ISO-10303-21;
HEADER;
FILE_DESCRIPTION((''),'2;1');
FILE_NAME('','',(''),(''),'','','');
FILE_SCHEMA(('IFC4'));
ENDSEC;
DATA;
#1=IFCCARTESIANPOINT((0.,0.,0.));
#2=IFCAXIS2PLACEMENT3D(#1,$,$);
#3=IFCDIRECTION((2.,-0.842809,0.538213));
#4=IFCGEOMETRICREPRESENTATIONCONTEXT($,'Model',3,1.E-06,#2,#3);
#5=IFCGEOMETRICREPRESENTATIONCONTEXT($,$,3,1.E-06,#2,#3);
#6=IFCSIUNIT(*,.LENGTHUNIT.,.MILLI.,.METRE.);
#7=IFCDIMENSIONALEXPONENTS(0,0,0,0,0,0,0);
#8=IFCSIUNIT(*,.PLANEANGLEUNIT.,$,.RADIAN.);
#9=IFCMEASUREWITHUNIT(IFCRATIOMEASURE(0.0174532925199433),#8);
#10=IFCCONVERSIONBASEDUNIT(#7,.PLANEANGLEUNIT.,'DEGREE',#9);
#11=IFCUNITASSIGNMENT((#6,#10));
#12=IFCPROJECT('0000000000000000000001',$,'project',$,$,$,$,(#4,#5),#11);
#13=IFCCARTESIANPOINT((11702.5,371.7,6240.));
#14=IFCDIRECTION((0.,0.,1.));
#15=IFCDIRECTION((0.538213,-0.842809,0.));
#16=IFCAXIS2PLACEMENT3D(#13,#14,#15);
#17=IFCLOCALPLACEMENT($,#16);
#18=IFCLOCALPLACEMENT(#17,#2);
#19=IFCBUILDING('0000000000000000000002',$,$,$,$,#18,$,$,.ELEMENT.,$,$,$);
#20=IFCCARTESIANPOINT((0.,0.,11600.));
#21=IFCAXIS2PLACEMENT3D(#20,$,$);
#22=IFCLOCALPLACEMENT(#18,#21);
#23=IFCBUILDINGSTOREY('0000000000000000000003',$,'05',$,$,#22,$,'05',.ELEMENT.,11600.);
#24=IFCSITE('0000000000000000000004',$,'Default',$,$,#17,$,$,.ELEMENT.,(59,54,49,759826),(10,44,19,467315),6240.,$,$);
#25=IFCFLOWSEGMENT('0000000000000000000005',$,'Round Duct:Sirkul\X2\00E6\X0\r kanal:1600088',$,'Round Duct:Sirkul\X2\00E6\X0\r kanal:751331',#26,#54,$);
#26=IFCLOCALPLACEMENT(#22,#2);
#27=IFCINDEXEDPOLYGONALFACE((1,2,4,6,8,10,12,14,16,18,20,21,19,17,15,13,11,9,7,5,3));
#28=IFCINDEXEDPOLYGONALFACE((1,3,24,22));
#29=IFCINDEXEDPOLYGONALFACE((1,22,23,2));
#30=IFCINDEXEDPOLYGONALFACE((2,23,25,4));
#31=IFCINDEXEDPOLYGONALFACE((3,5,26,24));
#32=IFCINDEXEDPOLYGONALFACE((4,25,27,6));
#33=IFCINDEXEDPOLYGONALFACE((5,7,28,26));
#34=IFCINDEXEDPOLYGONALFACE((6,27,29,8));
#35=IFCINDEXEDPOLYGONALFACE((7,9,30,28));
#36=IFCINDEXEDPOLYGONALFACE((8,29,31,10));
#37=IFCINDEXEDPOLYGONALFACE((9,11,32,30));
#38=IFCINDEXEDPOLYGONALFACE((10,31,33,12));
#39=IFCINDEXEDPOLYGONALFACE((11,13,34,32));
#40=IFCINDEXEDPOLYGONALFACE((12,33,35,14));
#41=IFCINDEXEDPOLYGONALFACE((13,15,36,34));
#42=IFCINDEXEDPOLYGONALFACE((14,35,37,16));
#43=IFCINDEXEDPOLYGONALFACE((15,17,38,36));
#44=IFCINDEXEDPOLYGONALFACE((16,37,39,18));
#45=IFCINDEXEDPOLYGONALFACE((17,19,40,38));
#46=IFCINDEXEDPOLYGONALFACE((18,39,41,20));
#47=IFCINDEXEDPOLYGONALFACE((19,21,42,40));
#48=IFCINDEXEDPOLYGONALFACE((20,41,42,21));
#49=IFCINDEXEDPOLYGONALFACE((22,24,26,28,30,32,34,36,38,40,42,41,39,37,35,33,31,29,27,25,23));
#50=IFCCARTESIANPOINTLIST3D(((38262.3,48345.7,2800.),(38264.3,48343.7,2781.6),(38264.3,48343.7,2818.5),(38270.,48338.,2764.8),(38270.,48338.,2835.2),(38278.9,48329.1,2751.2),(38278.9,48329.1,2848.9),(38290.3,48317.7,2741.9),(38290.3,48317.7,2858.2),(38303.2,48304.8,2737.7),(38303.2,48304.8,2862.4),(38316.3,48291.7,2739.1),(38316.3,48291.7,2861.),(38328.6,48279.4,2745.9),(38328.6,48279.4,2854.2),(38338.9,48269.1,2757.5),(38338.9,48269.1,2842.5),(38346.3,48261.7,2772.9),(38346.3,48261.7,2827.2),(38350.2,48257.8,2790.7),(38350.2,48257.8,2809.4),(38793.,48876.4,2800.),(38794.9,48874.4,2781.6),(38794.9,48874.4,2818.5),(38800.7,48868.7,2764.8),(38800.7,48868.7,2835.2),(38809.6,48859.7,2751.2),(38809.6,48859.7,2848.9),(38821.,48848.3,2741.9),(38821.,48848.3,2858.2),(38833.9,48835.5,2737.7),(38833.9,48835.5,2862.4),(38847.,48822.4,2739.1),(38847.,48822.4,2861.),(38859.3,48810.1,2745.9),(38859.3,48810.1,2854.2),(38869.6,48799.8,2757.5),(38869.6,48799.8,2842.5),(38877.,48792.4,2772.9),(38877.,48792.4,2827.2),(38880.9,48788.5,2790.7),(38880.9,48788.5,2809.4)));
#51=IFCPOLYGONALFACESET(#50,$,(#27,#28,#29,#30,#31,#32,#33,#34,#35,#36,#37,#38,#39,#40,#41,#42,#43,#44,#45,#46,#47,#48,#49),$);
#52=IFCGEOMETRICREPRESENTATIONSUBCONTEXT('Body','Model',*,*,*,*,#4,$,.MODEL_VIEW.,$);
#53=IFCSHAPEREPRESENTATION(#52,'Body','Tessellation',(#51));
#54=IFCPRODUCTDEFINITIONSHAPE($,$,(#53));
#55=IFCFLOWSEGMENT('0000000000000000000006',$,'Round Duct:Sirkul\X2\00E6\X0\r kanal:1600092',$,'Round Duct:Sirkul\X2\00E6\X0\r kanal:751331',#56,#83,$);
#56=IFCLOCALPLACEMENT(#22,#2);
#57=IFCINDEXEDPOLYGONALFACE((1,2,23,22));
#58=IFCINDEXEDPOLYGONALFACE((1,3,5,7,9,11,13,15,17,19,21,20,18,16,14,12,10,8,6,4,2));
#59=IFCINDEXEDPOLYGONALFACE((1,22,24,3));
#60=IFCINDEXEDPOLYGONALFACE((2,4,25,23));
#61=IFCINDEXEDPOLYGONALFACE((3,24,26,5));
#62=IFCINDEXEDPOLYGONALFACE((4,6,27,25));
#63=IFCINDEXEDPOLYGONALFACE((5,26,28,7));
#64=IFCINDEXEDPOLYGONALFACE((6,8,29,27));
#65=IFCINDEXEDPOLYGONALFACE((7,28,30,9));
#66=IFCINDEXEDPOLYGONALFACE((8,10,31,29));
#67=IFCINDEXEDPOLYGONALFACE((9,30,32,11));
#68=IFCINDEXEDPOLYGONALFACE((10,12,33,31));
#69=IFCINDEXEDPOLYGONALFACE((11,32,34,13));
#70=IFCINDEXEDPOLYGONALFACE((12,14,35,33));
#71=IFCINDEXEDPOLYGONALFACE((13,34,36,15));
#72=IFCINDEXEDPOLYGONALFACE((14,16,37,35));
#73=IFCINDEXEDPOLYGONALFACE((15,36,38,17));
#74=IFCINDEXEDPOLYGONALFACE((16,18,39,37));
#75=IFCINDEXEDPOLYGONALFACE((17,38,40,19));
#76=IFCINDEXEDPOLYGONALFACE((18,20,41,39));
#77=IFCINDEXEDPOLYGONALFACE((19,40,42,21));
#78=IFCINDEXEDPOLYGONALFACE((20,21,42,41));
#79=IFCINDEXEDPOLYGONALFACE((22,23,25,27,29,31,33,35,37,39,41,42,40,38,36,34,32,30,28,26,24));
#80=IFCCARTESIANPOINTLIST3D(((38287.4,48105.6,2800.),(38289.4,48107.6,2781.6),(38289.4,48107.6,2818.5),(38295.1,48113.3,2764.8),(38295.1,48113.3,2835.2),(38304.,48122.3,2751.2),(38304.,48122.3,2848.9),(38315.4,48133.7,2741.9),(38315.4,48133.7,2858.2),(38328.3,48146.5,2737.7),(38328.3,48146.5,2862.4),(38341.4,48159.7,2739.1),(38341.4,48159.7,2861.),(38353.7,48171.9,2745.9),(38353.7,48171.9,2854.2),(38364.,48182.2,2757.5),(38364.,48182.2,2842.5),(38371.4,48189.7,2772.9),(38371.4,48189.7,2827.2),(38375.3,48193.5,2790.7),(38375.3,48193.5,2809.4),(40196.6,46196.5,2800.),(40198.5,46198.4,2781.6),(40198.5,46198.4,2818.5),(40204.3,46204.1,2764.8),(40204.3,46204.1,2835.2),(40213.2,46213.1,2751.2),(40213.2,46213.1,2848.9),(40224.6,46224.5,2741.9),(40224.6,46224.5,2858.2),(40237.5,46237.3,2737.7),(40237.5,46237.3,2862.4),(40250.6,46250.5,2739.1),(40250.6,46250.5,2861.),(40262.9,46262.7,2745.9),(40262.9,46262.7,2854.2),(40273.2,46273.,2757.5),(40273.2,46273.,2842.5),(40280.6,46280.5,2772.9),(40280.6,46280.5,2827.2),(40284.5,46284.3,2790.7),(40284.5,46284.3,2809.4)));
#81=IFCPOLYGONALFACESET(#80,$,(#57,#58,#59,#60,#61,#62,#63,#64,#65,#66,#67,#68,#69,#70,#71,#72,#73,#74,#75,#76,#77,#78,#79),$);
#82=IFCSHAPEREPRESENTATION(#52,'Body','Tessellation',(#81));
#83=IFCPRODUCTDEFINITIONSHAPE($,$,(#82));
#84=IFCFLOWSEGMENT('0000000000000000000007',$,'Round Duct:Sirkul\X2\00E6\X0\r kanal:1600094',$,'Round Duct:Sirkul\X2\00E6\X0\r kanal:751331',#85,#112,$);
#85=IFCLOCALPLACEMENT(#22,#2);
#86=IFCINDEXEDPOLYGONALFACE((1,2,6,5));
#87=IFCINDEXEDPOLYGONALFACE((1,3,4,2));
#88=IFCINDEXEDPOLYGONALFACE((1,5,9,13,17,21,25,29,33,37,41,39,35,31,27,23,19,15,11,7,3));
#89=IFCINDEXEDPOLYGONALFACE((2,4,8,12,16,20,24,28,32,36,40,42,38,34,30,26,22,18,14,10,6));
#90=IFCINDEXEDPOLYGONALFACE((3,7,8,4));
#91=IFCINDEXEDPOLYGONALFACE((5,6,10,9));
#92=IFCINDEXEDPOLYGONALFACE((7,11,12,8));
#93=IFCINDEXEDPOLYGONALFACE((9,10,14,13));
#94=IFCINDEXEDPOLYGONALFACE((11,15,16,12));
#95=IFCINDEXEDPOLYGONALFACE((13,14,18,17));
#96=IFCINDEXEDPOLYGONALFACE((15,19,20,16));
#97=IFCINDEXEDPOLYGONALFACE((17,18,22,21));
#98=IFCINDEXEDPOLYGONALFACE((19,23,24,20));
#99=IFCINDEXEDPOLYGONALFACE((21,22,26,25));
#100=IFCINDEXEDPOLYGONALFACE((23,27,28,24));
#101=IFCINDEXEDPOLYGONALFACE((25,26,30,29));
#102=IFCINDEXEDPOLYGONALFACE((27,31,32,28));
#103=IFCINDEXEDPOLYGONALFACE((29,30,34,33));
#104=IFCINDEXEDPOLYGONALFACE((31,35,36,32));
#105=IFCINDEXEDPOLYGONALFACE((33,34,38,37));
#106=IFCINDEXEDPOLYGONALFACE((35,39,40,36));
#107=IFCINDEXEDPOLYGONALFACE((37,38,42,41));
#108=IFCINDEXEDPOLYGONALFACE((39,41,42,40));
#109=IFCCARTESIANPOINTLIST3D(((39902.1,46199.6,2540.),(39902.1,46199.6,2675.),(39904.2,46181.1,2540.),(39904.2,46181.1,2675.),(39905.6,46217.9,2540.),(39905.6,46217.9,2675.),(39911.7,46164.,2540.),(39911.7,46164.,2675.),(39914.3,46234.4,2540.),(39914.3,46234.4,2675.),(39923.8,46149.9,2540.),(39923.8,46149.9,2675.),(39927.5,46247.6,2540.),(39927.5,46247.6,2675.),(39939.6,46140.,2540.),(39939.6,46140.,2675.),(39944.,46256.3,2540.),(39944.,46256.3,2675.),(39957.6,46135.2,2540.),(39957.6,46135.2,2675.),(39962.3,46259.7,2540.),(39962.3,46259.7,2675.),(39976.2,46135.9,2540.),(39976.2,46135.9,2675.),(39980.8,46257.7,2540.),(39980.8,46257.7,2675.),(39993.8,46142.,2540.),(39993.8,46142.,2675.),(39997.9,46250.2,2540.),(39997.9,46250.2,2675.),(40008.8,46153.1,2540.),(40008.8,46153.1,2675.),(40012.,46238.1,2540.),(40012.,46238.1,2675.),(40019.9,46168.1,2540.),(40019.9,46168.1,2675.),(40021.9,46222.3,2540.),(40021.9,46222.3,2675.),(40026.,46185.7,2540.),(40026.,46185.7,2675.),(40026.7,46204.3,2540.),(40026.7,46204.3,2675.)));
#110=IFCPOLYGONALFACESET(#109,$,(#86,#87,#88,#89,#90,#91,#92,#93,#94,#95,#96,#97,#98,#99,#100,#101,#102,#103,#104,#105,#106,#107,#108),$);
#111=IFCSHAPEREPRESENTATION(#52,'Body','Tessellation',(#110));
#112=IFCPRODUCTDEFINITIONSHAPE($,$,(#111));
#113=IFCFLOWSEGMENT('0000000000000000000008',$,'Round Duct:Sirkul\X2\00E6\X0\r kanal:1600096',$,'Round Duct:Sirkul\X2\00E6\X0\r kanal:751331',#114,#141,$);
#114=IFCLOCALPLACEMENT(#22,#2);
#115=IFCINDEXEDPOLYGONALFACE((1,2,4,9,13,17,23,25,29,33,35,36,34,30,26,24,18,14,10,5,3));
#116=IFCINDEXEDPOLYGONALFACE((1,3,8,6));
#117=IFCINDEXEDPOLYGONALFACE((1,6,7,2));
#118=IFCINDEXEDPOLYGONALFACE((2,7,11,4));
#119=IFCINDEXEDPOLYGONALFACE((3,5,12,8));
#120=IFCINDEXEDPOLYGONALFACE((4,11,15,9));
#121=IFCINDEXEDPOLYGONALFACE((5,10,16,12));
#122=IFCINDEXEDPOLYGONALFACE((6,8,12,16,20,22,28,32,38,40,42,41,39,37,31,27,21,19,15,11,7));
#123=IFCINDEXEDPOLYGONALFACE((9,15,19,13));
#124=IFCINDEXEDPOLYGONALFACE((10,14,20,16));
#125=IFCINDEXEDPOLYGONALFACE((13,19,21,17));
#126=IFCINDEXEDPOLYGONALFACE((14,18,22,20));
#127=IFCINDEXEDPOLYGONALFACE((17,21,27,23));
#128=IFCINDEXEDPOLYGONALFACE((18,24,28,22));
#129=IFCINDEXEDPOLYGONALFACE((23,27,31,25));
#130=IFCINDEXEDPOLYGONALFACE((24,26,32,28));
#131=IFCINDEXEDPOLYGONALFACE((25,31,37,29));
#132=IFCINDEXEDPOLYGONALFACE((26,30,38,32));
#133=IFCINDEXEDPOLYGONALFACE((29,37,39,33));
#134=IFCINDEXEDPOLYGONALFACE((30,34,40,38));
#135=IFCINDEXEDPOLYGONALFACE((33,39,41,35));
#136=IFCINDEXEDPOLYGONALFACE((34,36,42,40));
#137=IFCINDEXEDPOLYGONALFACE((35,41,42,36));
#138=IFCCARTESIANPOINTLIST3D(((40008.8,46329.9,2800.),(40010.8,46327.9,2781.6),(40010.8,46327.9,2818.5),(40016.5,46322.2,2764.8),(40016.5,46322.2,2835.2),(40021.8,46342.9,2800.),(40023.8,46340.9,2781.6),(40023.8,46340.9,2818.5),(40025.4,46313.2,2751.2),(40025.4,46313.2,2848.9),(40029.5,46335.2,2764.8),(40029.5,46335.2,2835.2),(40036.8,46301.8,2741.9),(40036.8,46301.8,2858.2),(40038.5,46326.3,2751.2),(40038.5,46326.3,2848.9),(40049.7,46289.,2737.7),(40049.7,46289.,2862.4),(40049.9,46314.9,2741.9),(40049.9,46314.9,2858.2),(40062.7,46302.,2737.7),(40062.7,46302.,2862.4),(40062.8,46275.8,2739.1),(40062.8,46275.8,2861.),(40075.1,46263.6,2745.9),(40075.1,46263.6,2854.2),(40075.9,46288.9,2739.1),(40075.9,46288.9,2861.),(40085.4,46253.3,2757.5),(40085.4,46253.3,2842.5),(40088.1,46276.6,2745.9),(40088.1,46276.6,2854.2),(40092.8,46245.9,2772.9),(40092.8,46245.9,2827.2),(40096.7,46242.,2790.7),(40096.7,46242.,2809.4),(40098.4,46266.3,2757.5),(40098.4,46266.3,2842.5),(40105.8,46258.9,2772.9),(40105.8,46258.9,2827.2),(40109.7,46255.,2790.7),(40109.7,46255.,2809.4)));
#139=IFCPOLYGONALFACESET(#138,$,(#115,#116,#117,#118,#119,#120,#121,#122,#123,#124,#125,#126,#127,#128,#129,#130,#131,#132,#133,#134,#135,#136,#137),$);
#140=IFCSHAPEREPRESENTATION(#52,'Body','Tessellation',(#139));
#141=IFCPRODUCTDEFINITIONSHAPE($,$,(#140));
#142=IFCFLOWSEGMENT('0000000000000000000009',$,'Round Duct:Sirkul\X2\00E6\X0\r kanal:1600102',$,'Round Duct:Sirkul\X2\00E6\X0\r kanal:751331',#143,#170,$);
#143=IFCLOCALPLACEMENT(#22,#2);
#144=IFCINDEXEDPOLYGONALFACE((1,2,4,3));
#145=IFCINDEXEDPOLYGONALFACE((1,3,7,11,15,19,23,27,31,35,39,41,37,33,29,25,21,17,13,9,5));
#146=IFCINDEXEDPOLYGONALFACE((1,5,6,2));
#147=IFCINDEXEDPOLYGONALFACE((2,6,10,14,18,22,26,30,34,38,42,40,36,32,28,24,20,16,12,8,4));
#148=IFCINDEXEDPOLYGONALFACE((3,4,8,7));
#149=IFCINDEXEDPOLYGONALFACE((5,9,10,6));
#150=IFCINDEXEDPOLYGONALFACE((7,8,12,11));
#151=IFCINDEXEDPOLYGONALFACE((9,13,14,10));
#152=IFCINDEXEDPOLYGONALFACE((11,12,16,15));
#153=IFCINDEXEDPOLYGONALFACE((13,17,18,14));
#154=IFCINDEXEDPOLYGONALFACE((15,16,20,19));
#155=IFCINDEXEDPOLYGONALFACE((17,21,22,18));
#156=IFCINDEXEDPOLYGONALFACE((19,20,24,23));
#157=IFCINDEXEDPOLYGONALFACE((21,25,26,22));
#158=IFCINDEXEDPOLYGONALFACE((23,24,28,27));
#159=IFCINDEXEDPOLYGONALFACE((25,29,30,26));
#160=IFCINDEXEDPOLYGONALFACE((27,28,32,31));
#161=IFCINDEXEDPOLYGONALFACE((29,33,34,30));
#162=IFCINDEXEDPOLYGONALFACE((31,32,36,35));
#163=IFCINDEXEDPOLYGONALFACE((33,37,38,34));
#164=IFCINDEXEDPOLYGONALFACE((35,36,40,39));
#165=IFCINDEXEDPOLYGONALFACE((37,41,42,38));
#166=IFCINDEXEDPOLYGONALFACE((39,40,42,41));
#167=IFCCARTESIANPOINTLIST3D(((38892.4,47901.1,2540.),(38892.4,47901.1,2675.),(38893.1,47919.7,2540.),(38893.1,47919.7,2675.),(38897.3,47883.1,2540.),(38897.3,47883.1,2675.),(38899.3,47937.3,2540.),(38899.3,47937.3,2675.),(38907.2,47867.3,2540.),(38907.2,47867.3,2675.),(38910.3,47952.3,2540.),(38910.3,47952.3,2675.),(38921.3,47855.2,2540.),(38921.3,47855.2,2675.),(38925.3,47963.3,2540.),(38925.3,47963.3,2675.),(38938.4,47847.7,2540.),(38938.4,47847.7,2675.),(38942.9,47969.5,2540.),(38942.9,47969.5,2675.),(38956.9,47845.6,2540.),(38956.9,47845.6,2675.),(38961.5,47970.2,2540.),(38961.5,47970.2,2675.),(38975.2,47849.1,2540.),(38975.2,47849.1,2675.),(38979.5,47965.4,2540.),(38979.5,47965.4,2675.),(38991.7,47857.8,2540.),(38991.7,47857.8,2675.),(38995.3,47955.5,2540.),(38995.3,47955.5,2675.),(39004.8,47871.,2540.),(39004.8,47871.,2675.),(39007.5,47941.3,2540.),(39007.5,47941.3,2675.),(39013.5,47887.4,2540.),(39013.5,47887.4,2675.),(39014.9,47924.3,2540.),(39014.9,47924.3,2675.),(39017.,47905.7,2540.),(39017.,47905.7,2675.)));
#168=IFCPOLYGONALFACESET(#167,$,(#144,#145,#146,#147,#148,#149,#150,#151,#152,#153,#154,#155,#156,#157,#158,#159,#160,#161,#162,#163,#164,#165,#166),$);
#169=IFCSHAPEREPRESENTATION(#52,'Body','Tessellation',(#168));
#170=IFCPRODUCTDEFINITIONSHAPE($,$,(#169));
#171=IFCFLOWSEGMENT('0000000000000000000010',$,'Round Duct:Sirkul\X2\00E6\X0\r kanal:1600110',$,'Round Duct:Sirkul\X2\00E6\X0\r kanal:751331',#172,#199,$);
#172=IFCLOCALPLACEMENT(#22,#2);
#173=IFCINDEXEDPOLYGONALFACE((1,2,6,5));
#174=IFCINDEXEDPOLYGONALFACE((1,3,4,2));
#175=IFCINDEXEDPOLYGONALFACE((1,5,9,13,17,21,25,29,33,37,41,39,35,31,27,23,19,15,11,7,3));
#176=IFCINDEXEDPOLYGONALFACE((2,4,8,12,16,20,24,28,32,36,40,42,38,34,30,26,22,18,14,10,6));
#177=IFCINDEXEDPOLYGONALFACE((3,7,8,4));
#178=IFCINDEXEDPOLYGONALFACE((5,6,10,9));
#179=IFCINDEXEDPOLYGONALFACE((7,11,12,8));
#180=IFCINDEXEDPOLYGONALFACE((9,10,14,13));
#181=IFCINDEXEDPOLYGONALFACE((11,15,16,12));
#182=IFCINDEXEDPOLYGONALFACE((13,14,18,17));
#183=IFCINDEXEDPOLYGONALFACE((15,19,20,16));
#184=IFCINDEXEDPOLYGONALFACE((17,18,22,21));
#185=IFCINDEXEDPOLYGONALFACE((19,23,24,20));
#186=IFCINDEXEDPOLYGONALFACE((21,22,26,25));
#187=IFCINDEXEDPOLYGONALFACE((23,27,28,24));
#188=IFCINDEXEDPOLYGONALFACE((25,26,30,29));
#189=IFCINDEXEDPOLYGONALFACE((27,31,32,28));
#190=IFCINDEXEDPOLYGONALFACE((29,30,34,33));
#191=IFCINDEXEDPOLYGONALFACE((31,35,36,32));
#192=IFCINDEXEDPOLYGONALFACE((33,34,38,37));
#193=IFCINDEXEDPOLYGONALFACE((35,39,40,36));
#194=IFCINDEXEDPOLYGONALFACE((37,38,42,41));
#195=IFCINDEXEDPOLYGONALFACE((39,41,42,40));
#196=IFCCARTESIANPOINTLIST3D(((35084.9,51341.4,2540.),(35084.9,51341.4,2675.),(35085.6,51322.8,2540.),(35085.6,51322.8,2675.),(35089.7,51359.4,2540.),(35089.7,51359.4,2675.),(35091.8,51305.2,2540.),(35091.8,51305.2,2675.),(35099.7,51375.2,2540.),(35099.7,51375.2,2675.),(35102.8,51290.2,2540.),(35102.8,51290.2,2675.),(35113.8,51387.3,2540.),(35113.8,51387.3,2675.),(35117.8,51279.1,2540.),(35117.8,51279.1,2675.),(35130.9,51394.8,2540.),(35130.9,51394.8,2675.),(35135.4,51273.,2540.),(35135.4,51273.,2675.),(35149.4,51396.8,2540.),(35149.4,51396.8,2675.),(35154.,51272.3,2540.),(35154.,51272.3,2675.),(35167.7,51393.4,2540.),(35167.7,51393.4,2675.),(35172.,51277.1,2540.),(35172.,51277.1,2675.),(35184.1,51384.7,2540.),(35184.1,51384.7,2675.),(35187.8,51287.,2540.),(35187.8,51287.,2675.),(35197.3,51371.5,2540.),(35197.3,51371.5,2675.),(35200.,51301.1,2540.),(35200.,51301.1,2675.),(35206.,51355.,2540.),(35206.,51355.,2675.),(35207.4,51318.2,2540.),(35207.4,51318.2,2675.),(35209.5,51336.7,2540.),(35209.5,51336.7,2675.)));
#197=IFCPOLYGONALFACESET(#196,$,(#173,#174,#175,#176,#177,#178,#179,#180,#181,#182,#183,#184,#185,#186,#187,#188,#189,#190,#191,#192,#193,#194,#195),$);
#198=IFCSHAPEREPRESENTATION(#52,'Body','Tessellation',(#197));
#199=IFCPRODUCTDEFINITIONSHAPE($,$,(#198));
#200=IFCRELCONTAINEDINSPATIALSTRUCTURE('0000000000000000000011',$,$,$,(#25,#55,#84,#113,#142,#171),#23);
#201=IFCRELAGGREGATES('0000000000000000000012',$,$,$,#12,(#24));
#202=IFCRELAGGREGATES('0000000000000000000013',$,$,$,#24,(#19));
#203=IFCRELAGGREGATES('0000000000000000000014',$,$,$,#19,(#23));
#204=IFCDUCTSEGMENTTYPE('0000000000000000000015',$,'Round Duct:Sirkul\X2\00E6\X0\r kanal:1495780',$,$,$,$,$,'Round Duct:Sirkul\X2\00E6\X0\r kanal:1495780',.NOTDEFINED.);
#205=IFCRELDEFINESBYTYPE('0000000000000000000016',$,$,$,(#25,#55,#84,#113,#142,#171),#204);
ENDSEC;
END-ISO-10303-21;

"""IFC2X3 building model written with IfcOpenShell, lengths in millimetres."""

from ifc_helpers import new_model, entity, si_unit, converted_unit, direction, frame, frame_2d, origin, origin_2d_with_axis, place, context, subcontext, project, spatial, circle, extrude, type_object, element, save


model = new_model("IFC2X3")

# Units and contexts
model_context = context("Model", 3, precision=1e-06, world=origin(), true_north=direction((2.0, -0.842809, 0.538213)))
context_of_model = context(None, 3, precision=1e-06, world=origin(), true_north=direction((2.0, -0.842809, 0.538213)))
body_context = subcontext(model_context, "Body", "Model", "MODEL_VIEW")
ifc_project = project(units=[si_unit("LENGTHUNIT", "METRE", prefix="MILLI"), converted_unit("PLANEANGLEUNIT", "DEGREE", entity("IfcRatioMeasure", 0.0174532925199433), si_unit("PLANEANGLEUNIT", "RADIAN"), dimensions=[0, 0, 0, 0, 0, 0, 0])], contexts=[model_context, context_of_model])

# Site, building, storey
site_placement = place(None, frame((11702.5, 371.7, 6240.0), z_axis=(0.0, 0.0, 1.0), x_axis=(0.538213, -0.842809, 0.0)))
site = spatial("IfcSite", under=ifc_project, at=site_placement, Name="Default", CompositionType="ELEMENT", RefLatitude=(59, 54, 49, 759826), RefLongitude=(10, 44, 19, 467315), RefElevation=6240.0)
building_placement = place(site_placement, origin())
building = spatial("IfcBuilding", under=site, at=building_placement, CompositionType="ELEMENT")
storey_placement = place(building_placement, frame((0.0, 0.0, 11600.0)))
storey = spatial("IfcBuildingStorey", under=building, at=storey_placement, Name="05", LongName="05", CompositionType="ELEMENT", Elevation=11600.0)

# Flow segments
duct_segment_type = type_object("IfcDuctSegmentType", Name="Round Duct:Sirkulær kanal:1495780", ElementType="Round Duct:Sirkulær kanal:1495780", PredefinedType="NOTDEFINED")
flow_segment_1_placement = place(storey_placement, origin())
element("IfcFlowSegment", 1, at=flow_segment_1_placement, inside=storey, type_object=duct_segment_type, Name="Round Duct:Sirkulær kanal:1600088", ObjectType="Round Duct:Sirkulær kanal:751331", context=body_context, shape_type="SweptSolid", body=[
    extrude(circle(Radius=62.5, at=origin_2d_with_axis()), frame((38306.5, 48301.5, 2800.0), z_axis=(0.707107, 0.707107, 0.0), x_axis=(-0.707107, 0.707107, 0.0)), (0.0, 0.0, 1.0), 750.5),
])
flow_segment_2_placement = place(storey_placement, origin())
element("IfcFlowSegment", 2, at=flow_segment_2_placement, inside=storey, type_object=duct_segment_type, Name="Round Duct:Sirkulær kanal:1600092", ObjectType="Round Duct:Sirkulær kanal:751331", context=body_context, shape_type="SweptSolid", body=[
    extrude(circle(Radius=62.5, at=origin_2d_with_axis()), frame((38331.6, 48149.8, 2800.0), z_axis=(0.707107, -0.707107, 0.0), x_axis=(-0.707107, -0.707107, 0.0)), (0.0, 0.0, 1.0), 2700.0),
])
flow_segment_3_placement = place(storey_placement, origin())
element("IfcFlowSegment", 3, at=flow_segment_3_placement, inside=storey, type_object=duct_segment_type, Name="Round Duct:Sirkulær kanal:1600094", ObjectType="Round Duct:Sirkulær kanal:751331", context=body_context, shape_type="SweptSolid", body=[
    extrude(circle(Radius=62.5, at=origin_2d_with_axis()), frame((39964.6, 46197.3, 2540.0), z_axis=(0.0, 0.0, 1.0), x_axis=(0.707107, -0.707107, 0.0)), (0.0, 0.0, 1.0), 135.0),
])
flow_segment_4_placement = place(storey_placement, origin())
element("IfcFlowSegment", 4, at=flow_segment_4_placement, inside=storey, type_object=duct_segment_type, Name="Round Duct:Sirkulær kanal:1600096", ObjectType="Round Duct:Sirkulær kanal:751331", context=body_context, shape_type="SweptSolid", body=[
    extrude(circle(Radius=62.5, at=frame_2d((0.0, 0.0), x_axis=(1.0, 0.0))), frame((40053.0, 46285.7, 2800.0), z_axis=(0.707107, 0.707107, 0.0), x_axis=(-0.707107, 0.707107, 0.0)), (0.0, 0.0, 1.0), 18.4),
])
flow_segment_5_placement = place(storey_placement, origin())
element("IfcFlowSegment", 5, at=flow_segment_5_placement, inside=storey, type_object=duct_segment_type, Name="Round Duct:Sirkulær kanal:1600102", ObjectType="Round Duct:Sirkulær kanal:751331", context=body_context, shape_type="SweptSolid", body=[
    extrude(circle(Radius=62.5, at=frame_2d((0.0, 0.0), x_axis=(1.0, 0.0))), frame((38954.5, 47908.1, 2540.0), z_axis=(0.0, 0.0, 1.0), x_axis=(-0.707107, 0.707107, 0.0)), (0.0, 0.0, 1.0), 135.0),
])
flow_segment_6_placement = place(storey_placement, origin())
element("IfcFlowSegment", 6, at=flow_segment_6_placement, inside=storey, type_object=duct_segment_type, Name="Round Duct:Sirkulær kanal:1600110", ObjectType="Round Duct:Sirkulær kanal:751331", context=body_context, shape_type="SweptSolid", body=[
    extrude(circle(Radius=62.5, at=origin_2d_with_axis()), frame((35147.0, 51334.4, 2540.0), z_axis=(0.0, 0.0, 1.0), x_axis=(-0.707107, -0.707107, 0.0)), (0.0, 0.0, 1.0), 135.0),
])

save(model, "model.ifc")
